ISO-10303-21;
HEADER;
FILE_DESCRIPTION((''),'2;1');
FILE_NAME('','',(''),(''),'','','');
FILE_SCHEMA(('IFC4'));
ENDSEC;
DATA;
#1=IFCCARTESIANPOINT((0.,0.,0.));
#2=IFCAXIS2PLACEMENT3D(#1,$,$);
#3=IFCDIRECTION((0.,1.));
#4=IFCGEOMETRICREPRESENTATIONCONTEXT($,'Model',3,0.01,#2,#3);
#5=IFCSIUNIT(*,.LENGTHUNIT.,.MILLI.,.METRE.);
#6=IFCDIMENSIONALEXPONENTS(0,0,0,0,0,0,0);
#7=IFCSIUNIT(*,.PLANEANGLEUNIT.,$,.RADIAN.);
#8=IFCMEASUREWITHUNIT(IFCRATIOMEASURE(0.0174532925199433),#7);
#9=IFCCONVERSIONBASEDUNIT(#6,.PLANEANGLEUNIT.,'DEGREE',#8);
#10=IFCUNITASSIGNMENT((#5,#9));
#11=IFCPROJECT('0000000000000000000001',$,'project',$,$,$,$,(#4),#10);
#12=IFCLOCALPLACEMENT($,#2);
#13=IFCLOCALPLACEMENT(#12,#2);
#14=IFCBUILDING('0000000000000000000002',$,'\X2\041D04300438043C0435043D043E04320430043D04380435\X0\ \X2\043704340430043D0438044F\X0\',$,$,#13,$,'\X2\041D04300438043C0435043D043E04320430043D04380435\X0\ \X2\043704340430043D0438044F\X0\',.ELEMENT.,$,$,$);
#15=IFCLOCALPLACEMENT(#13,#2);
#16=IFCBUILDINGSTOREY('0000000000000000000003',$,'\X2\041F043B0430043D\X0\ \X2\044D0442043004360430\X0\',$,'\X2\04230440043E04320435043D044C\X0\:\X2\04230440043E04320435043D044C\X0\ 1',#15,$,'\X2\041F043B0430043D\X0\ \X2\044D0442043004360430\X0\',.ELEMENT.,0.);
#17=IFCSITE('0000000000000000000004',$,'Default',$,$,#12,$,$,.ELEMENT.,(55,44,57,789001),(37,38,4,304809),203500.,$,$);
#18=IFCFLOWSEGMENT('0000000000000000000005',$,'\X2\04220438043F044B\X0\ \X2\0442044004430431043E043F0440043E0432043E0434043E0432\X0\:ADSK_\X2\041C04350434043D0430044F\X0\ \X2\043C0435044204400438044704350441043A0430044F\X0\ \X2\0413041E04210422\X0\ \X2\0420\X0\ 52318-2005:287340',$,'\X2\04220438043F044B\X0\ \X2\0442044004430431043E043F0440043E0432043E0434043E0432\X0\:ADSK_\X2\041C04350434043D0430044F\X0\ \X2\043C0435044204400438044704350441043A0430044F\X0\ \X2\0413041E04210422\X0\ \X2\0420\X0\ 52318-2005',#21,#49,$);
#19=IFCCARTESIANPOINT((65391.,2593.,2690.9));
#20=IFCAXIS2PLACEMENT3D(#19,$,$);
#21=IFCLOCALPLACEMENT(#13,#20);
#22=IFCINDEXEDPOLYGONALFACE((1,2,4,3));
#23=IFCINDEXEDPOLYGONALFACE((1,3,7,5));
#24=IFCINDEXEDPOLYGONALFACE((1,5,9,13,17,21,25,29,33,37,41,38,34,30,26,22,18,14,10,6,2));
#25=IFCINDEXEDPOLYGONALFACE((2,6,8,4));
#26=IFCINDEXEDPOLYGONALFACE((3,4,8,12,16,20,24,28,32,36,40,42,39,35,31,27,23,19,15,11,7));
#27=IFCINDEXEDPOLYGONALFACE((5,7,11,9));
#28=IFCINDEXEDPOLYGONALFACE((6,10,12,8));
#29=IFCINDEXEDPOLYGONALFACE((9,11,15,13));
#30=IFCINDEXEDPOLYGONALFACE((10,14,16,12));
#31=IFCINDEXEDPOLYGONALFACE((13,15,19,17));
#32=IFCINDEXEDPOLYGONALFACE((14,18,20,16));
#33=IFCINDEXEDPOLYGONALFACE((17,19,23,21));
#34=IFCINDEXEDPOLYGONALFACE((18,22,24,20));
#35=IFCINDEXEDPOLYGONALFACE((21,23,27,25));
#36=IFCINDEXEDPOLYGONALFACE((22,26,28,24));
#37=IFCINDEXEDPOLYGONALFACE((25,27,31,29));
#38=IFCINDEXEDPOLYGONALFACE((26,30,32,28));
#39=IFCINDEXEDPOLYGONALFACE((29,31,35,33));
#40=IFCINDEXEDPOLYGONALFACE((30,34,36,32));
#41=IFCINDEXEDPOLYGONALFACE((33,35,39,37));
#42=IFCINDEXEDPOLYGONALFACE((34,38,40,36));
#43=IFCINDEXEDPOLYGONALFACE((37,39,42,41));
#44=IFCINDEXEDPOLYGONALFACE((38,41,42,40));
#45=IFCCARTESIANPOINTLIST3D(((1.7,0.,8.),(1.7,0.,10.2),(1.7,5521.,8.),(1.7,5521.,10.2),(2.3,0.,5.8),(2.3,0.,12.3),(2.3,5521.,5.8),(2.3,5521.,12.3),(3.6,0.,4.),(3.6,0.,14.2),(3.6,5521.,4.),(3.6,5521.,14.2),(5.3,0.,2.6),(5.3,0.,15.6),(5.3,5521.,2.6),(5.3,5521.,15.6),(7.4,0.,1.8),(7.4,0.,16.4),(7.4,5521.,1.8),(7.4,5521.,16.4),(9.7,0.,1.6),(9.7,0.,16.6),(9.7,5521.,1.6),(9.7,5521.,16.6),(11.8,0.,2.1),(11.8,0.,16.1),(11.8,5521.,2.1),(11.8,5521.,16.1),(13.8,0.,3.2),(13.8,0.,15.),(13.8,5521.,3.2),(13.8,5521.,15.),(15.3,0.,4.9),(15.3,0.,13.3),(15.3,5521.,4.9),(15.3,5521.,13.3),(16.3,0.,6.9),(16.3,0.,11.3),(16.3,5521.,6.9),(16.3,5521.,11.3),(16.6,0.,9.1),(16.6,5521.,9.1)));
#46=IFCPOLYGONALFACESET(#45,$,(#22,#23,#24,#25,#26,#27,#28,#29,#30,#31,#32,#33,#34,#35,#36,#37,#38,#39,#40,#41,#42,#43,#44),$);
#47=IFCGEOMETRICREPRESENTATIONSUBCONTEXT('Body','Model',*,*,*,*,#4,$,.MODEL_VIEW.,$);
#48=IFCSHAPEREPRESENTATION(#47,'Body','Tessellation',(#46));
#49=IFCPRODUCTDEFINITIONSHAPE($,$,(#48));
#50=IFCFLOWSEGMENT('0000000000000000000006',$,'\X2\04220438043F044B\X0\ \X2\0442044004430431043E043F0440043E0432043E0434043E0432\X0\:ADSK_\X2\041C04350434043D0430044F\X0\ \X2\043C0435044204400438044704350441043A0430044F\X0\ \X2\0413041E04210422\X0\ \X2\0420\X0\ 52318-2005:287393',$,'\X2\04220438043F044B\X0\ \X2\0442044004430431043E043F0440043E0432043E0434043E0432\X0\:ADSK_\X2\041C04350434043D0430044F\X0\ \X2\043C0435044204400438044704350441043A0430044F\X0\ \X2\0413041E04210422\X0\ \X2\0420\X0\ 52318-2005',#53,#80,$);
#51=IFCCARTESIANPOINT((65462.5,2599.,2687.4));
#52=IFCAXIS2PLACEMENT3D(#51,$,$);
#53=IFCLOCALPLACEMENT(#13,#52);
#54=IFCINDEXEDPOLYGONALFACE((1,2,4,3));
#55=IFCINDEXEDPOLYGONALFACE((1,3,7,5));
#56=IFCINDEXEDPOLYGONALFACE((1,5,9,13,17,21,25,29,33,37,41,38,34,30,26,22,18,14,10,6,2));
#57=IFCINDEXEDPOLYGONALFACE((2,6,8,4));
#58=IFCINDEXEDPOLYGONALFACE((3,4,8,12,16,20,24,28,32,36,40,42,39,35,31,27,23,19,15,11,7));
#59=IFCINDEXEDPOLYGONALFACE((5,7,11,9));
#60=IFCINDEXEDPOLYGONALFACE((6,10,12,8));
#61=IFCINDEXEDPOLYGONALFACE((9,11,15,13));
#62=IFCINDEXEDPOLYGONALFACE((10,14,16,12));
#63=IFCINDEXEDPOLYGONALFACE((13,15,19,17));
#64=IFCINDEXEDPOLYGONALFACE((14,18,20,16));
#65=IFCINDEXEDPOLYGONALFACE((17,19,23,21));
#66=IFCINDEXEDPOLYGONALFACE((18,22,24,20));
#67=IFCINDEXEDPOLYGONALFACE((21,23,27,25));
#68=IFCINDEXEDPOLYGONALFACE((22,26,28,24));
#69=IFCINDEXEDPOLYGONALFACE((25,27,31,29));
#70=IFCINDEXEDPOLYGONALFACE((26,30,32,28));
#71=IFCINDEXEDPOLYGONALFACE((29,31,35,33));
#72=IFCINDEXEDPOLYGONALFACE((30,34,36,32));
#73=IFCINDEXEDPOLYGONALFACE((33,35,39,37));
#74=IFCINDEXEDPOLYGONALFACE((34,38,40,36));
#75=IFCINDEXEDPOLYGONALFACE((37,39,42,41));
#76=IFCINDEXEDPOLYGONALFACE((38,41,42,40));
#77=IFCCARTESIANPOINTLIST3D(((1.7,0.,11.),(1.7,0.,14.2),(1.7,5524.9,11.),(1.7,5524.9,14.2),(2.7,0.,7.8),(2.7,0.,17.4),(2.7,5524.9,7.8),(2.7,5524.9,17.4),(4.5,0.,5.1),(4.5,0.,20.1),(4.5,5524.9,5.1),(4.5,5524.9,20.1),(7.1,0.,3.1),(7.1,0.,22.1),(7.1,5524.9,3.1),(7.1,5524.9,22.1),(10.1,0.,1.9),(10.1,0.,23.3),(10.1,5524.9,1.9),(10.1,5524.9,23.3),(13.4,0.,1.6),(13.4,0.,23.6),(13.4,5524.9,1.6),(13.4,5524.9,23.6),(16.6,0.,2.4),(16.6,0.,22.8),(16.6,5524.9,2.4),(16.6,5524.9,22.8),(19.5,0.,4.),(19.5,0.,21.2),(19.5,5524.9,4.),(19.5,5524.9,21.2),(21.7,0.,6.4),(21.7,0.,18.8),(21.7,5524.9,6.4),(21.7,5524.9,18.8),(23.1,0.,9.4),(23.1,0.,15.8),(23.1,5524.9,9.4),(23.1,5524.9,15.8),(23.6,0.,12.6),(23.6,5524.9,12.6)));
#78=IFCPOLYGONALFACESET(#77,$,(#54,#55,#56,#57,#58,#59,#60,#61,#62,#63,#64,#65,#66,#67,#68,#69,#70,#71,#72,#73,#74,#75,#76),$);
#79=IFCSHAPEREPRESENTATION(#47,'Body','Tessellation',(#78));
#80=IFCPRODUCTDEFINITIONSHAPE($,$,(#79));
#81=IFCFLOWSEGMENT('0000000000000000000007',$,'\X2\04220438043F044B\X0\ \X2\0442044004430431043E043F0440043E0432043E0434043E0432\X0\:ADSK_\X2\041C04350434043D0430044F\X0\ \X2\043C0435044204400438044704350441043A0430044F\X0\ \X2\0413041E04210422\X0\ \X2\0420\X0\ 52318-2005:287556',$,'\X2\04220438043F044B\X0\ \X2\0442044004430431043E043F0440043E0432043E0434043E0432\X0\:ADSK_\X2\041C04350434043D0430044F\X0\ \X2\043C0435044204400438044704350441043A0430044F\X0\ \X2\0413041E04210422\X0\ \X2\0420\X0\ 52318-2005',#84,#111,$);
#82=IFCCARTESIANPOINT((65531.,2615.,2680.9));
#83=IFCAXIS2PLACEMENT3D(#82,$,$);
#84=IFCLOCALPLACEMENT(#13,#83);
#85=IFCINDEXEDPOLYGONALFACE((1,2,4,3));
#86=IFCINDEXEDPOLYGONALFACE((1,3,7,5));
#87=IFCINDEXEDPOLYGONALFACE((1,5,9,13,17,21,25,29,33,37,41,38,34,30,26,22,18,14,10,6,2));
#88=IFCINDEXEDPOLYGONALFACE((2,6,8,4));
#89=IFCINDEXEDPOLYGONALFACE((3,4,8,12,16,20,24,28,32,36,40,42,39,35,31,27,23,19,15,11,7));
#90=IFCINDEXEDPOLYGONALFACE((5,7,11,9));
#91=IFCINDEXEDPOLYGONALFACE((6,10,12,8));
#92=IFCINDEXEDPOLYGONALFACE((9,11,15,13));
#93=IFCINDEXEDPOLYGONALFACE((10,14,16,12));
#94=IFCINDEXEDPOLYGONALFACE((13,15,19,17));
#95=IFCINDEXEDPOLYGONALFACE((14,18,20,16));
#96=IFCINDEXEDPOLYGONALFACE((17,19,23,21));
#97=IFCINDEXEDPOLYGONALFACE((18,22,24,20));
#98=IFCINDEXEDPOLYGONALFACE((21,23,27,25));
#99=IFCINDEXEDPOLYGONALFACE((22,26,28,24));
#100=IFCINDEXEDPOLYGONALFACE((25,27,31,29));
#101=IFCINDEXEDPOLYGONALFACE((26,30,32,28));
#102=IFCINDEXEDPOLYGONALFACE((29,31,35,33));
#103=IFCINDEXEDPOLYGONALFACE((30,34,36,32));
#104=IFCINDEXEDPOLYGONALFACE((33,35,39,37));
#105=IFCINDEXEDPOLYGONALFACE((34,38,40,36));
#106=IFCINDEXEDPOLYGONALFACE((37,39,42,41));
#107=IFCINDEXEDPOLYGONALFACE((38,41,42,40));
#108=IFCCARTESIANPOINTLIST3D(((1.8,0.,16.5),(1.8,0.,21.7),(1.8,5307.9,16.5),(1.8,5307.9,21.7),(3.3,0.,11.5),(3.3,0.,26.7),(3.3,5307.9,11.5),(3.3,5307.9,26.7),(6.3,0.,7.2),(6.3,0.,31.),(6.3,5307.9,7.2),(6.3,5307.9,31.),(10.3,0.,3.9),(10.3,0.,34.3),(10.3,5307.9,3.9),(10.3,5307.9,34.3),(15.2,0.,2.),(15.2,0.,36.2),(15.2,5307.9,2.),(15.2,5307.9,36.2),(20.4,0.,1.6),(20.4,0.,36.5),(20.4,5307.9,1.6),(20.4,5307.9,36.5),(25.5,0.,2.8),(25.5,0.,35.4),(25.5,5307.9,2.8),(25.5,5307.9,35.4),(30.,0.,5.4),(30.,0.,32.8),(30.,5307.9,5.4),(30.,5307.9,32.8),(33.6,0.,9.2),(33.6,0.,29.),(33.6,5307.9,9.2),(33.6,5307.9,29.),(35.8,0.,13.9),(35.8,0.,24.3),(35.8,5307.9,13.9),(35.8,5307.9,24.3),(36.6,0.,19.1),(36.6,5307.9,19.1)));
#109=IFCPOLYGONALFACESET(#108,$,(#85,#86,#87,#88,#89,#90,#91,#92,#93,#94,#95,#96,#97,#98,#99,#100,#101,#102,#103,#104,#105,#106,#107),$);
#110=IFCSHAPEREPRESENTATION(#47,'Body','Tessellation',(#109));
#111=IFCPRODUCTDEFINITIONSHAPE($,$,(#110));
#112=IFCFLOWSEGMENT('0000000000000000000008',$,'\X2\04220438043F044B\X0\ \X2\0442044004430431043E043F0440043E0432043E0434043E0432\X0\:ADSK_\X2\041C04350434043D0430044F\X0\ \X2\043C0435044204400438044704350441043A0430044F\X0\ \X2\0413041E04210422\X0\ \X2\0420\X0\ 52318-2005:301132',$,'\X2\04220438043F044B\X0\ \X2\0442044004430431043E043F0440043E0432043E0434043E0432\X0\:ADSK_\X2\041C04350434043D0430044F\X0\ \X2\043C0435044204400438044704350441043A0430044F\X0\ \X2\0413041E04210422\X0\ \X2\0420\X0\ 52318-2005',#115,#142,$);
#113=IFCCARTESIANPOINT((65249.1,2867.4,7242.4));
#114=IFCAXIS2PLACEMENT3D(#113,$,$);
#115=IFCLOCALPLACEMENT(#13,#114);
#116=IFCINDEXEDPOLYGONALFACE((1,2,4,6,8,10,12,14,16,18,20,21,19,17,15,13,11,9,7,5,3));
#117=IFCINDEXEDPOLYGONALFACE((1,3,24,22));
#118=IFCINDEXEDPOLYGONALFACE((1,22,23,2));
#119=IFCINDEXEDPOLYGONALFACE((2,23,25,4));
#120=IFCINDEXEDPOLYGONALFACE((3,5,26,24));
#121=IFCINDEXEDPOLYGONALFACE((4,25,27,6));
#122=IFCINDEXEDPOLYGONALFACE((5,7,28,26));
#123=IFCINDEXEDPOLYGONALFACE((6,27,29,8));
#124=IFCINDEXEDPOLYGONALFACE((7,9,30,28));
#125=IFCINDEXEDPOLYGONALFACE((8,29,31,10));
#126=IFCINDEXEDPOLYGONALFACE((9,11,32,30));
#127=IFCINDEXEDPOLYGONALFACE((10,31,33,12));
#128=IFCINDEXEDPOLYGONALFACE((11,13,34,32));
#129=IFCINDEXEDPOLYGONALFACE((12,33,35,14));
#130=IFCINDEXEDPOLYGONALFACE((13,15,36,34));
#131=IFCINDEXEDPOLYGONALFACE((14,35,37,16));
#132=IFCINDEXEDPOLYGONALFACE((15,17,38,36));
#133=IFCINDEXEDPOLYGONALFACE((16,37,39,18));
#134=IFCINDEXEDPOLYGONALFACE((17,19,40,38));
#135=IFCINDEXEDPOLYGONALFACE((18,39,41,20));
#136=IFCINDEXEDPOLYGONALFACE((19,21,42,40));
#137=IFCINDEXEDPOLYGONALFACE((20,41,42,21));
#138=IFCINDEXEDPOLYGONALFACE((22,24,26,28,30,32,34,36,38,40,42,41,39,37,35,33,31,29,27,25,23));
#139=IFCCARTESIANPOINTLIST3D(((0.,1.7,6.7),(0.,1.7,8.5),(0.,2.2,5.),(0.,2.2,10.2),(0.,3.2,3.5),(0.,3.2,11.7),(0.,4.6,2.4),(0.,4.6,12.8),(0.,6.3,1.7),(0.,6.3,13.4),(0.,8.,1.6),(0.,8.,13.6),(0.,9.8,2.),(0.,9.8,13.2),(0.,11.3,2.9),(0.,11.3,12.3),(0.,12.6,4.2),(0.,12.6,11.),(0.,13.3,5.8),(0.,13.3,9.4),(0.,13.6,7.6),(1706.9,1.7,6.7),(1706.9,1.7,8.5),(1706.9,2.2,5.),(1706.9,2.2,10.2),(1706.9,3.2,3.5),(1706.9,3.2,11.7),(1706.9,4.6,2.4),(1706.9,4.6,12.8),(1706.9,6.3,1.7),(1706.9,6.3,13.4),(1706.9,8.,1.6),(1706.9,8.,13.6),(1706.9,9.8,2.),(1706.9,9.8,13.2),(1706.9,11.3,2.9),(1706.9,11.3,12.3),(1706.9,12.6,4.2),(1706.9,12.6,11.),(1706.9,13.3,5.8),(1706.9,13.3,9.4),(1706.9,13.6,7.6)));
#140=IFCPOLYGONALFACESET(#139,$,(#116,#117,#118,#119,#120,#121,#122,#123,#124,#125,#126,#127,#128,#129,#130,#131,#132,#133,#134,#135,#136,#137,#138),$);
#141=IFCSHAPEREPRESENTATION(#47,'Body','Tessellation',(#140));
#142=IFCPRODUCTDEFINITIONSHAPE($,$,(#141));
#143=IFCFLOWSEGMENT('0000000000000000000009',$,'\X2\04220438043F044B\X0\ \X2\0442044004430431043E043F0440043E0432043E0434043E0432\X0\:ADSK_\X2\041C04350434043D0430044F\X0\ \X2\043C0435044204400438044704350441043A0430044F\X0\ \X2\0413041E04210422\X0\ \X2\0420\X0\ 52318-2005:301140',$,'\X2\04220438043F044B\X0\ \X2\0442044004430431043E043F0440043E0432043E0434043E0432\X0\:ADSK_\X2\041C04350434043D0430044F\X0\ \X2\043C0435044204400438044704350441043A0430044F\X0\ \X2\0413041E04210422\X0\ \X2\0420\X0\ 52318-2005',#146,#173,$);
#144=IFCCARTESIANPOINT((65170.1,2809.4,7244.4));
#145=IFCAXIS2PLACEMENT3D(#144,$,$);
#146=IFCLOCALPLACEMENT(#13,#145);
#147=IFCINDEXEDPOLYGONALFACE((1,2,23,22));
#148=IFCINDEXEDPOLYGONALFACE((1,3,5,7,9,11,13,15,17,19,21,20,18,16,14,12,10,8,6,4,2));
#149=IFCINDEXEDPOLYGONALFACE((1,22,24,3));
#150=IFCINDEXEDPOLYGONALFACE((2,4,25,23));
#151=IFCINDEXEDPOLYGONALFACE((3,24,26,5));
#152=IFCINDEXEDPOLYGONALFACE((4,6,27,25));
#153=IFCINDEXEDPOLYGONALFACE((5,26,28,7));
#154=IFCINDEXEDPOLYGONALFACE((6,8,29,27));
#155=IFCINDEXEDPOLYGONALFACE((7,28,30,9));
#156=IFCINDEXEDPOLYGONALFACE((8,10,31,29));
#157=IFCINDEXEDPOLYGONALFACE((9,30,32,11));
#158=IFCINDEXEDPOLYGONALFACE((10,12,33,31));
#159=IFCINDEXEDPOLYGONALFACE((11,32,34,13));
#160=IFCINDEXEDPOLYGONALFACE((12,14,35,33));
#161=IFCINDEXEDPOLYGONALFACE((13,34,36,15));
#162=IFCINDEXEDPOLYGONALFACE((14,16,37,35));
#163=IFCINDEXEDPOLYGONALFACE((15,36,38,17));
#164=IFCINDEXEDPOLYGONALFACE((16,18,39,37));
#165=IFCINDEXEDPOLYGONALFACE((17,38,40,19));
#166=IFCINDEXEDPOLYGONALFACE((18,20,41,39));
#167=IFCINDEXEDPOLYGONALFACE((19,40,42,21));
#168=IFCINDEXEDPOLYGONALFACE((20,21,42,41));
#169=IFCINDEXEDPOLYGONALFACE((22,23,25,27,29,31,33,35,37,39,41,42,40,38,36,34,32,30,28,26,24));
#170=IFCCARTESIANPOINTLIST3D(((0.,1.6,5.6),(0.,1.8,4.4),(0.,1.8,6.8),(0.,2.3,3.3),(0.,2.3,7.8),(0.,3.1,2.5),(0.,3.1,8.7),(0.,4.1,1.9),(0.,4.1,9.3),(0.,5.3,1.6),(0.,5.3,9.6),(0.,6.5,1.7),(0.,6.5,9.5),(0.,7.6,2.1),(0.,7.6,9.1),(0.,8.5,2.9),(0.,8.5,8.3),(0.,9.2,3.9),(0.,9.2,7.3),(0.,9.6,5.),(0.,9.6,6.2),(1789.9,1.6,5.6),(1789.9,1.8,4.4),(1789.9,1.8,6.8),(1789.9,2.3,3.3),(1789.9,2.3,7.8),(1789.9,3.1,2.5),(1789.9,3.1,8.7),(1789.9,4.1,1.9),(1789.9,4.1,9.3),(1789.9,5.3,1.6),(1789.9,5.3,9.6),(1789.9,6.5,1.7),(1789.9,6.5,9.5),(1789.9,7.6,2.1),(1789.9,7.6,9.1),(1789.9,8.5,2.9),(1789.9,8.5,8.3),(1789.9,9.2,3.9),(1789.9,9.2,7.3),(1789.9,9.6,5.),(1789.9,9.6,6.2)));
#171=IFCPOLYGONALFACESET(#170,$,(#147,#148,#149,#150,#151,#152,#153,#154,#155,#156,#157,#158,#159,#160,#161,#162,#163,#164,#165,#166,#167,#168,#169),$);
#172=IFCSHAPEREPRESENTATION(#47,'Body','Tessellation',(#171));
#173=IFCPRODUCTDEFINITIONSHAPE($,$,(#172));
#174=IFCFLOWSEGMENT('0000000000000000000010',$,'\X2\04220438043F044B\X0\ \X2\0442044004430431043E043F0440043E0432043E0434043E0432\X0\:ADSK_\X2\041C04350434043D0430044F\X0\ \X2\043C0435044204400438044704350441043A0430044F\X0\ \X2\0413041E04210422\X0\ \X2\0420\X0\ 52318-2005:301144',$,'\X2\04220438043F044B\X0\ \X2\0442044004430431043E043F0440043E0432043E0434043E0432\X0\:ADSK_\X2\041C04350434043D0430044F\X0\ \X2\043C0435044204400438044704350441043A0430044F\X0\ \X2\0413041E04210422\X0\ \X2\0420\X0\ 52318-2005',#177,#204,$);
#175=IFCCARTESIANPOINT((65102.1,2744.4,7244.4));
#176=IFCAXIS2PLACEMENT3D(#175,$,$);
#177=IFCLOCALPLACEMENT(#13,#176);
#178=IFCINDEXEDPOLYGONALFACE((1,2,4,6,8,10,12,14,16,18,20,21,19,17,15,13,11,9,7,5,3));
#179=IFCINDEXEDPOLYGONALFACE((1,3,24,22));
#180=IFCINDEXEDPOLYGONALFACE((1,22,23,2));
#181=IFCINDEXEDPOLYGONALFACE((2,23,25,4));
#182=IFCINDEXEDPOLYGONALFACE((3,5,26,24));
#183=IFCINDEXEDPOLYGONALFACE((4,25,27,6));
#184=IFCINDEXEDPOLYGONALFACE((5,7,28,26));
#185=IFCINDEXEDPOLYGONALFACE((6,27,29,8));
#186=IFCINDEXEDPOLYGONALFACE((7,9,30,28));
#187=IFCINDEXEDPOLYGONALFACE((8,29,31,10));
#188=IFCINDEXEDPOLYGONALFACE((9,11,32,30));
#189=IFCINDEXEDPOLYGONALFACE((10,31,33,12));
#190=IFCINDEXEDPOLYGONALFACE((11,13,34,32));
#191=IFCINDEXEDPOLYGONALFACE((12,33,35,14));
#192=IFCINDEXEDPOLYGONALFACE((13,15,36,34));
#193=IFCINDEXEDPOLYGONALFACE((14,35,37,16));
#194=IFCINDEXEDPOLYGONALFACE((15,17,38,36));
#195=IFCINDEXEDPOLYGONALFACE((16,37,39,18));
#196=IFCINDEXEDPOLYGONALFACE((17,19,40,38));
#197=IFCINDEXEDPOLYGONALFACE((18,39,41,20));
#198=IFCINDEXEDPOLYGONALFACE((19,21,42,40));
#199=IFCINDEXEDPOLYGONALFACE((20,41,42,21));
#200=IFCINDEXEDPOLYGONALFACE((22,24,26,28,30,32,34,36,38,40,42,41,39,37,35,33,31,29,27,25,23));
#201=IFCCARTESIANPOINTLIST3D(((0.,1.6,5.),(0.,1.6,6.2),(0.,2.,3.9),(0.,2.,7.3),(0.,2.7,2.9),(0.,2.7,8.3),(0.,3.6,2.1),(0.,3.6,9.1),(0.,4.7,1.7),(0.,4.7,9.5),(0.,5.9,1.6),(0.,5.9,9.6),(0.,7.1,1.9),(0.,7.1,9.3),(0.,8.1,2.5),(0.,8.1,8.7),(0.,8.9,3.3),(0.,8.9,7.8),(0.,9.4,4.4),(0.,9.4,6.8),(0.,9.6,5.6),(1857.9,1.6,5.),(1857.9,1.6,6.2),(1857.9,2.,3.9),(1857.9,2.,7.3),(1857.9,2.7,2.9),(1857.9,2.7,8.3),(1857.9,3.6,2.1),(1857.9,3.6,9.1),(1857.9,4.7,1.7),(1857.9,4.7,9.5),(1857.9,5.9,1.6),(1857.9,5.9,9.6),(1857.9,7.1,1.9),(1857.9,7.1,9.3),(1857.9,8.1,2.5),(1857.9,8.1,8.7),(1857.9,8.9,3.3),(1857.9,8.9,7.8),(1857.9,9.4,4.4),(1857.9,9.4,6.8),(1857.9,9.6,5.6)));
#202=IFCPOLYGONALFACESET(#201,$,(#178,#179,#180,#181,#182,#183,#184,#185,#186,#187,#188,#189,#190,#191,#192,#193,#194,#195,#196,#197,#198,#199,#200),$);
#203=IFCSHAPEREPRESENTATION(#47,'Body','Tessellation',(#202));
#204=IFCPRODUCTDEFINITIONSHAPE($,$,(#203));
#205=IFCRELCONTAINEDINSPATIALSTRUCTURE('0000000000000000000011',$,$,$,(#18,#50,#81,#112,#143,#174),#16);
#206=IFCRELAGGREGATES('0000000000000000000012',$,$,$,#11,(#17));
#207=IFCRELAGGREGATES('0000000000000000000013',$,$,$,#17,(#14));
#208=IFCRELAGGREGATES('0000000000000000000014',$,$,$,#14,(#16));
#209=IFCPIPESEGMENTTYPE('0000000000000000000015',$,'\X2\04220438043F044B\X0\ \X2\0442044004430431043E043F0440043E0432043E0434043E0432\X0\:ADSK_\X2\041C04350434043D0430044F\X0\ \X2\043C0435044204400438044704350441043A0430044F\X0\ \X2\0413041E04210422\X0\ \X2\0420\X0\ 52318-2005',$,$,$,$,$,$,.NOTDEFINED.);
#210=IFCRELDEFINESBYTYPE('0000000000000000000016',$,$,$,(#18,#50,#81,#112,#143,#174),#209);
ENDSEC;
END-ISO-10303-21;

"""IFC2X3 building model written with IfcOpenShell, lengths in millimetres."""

from ifc_helpers import new_model, entity, si_unit, converted_unit, direction, frame, frame_2d, origin, origin_2d_with_axis, place, context, subcontext, project, spatial, circle, extrude, type_object, element, save


model = new_model("IFC2X3")

# Units and contexts
model_context = context("Model", 3, precision=0.01, world=origin(), true_north=direction((0.0, 1.0)))
body_context = subcontext(model_context, "Body", "Model", "MODEL_VIEW")
ifc_project = project(units=[si_unit("LENGTHUNIT", "METRE", prefix="MILLI"), converted_unit("PLANEANGLEUNIT", "DEGREE", entity("IfcRatioMeasure", 0.0174532925199433), si_unit("PLANEANGLEUNIT", "RADIAN"), dimensions=[0, 0, 0, 0, 0, 0, 0])], contexts=[model_context])

# Site, building, storey
site_placement = place(None, frame((0.0, 0.0, 0.0)))
site = spatial("IfcSite", under=ifc_project, at=site_placement, Name="Default", CompositionType="ELEMENT", RefLatitude=(55, 44, 57, 789001), RefLongitude=(37, 38, 4, 304809), RefElevation=203500.0)
building_placement = place(site_placement, origin())
building = spatial("IfcBuilding", under=site, at=building_placement, Name="Наименование здания", LongName="Наименование здания", CompositionType="ELEMENT")
storey_placement = place(building_placement, origin())
storey = spatial("IfcBuildingStorey", under=building, at=storey_placement, Name="План этажа", ObjectType="Уровень:Уровень 1", LongName="План этажа", CompositionType="ELEMENT", Elevation=0.0)

# Flow segments
pipe_segment_type = type_object("IfcPipeSegmentType", Name="Типы трубопроводов:ADSK_Медная метрическая ГОСТ Р 52318-2005", PredefinedType="NOTDEFINED")
flow_segment_1_placement = place(building_placement, frame((65391.0, 2593.0, 2690.9)))
element("IfcFlowSegment", 1, at=flow_segment_1_placement, inside=storey, type_object=pipe_segment_type, Name="Типы трубопроводов:ADSK_Медная метрическая ГОСТ Р 52318-2005:287340", ObjectType="Типы трубопроводов:ADSK_Медная метрическая ГОСТ Р 52318-2005", context=body_context, shape_type="SweptSolid", body=[
    extrude(circle(Radius=7.5, at=origin_2d_with_axis()), frame((9.1, 0.0, 9.1), z_axis=(0.0, 1.0, 0.0), x_axis=(1.0, 0.0, 0.0)), (0.0, 0.0, 1.0), 5521.0),
])
flow_segment_2_placement = place(building_placement, frame((65462.5, 2599.0, 2687.4)))
element("IfcFlowSegment", 2, at=flow_segment_2_placement, inside=storey, type_object=pipe_segment_type, Name="Типы трубопроводов:ADSK_Медная метрическая ГОСТ Р 52318-2005:287393", ObjectType="Типы трубопроводов:ADSK_Медная метрическая ГОСТ Р 52318-2005", context=body_context, shape_type="SweptSolid", body=[
    extrude(circle(Radius=11.0, at=frame_2d((0.0, 0.0), x_axis=(1.0, 0.0))), frame((12.6, 0.0, 12.6), z_axis=(0.0, 1.0, 0.0), x_axis=(1.0, 0.0, 0.0)), (0.0, 0.0, 1.0), 5524.9),
])
flow_segment_3_placement = place(building_placement, frame((65531.0, 2615.0, 2680.9)))
element("IfcFlowSegment", 3, at=flow_segment_3_placement, inside=storey, type_object=pipe_segment_type, Name="Типы трубопроводов:ADSK_Медная метрическая ГОСТ Р 52318-2005:287556", ObjectType="Типы трубопроводов:ADSK_Медная метрическая ГОСТ Р 52318-2005", context=body_context, shape_type="SweptSolid", body=[
    extrude(circle(Radius=17.5, at=origin_2d_with_axis()), frame((19.1, 0.0, 19.1), z_axis=(0.0, 1.0, 0.0), x_axis=(1.0, 0.0, 0.0)), (0.0, 0.0, 1.0), 5307.9),
])
flow_segment_4_placement = place(building_placement, frame((65249.1, 2867.4, 7242.4)))
element("IfcFlowSegment", 4, at=flow_segment_4_placement, inside=storey, type_object=pipe_segment_type, Name="Типы трубопроводов:ADSK_Медная метрическая ГОСТ Р 52318-2005:301132", ObjectType="Типы трубопроводов:ADSK_Медная метрическая ГОСТ Р 52318-2005", context=body_context, shape_type="SweptSolid", body=[
    extrude(circle(Radius=6.0, at=frame_2d((0.0, 0.0), x_axis=(1.0, 0.0))), frame((0.0, 7.6, 7.6), z_axis=(1.0, 0.0, 0.0), x_axis=(0.0, 1.0, 0.0)), (0.0, 0.0, 1.0), 1706.9),
])
flow_segment_5_placement = place(building_placement, frame((65170.1, 2809.4, 7244.4)))
element("IfcFlowSegment", 5, at=flow_segment_5_placement, inside=storey, type_object=pipe_segment_type, Name="Типы трубопроводов:ADSK_Медная метрическая ГОСТ Р 52318-2005:301140", ObjectType="Типы трубопроводов:ADSK_Медная метрическая ГОСТ Р 52318-2005", context=body_context, shape_type="SweptSolid", body=[
    extrude(circle(Radius=4.0, at=frame_2d((0.0, 0.0), x_axis=(1.0, 0.0))), frame((0.0, 5.6, 5.6), z_axis=(1.0, 0.0, 0.0), x_axis=(0.0, -1.0, 0.0)), (0.0, 0.0, 1.0), 1789.9),
])
flow_segment_6_placement = place(building_placement, frame((65102.1, 2744.4, 7244.4)))
element("IfcFlowSegment", 6, at=flow_segment_6_placement, inside=storey, type_object=pipe_segment_type, Name="Типы трубопроводов:ADSK_Медная метрическая ГОСТ Р 52318-2005:301144", ObjectType="Типы трубопроводов:ADSK_Медная метрическая ГОСТ Р 52318-2005", context=body_context, shape_type="SweptSolid", body=[
    extrude(circle(Radius=4.0, at=frame_2d((0.0, 0.0), x_axis=(1.0, 0.0))), frame((0.0, 5.6, 5.6), z_axis=(1.0, 0.0, 0.0), x_axis=(0.0, 1.0, 0.0)), (0.0, 0.0, 1.0), 1857.9),
])

save(model, "model.ifc")
